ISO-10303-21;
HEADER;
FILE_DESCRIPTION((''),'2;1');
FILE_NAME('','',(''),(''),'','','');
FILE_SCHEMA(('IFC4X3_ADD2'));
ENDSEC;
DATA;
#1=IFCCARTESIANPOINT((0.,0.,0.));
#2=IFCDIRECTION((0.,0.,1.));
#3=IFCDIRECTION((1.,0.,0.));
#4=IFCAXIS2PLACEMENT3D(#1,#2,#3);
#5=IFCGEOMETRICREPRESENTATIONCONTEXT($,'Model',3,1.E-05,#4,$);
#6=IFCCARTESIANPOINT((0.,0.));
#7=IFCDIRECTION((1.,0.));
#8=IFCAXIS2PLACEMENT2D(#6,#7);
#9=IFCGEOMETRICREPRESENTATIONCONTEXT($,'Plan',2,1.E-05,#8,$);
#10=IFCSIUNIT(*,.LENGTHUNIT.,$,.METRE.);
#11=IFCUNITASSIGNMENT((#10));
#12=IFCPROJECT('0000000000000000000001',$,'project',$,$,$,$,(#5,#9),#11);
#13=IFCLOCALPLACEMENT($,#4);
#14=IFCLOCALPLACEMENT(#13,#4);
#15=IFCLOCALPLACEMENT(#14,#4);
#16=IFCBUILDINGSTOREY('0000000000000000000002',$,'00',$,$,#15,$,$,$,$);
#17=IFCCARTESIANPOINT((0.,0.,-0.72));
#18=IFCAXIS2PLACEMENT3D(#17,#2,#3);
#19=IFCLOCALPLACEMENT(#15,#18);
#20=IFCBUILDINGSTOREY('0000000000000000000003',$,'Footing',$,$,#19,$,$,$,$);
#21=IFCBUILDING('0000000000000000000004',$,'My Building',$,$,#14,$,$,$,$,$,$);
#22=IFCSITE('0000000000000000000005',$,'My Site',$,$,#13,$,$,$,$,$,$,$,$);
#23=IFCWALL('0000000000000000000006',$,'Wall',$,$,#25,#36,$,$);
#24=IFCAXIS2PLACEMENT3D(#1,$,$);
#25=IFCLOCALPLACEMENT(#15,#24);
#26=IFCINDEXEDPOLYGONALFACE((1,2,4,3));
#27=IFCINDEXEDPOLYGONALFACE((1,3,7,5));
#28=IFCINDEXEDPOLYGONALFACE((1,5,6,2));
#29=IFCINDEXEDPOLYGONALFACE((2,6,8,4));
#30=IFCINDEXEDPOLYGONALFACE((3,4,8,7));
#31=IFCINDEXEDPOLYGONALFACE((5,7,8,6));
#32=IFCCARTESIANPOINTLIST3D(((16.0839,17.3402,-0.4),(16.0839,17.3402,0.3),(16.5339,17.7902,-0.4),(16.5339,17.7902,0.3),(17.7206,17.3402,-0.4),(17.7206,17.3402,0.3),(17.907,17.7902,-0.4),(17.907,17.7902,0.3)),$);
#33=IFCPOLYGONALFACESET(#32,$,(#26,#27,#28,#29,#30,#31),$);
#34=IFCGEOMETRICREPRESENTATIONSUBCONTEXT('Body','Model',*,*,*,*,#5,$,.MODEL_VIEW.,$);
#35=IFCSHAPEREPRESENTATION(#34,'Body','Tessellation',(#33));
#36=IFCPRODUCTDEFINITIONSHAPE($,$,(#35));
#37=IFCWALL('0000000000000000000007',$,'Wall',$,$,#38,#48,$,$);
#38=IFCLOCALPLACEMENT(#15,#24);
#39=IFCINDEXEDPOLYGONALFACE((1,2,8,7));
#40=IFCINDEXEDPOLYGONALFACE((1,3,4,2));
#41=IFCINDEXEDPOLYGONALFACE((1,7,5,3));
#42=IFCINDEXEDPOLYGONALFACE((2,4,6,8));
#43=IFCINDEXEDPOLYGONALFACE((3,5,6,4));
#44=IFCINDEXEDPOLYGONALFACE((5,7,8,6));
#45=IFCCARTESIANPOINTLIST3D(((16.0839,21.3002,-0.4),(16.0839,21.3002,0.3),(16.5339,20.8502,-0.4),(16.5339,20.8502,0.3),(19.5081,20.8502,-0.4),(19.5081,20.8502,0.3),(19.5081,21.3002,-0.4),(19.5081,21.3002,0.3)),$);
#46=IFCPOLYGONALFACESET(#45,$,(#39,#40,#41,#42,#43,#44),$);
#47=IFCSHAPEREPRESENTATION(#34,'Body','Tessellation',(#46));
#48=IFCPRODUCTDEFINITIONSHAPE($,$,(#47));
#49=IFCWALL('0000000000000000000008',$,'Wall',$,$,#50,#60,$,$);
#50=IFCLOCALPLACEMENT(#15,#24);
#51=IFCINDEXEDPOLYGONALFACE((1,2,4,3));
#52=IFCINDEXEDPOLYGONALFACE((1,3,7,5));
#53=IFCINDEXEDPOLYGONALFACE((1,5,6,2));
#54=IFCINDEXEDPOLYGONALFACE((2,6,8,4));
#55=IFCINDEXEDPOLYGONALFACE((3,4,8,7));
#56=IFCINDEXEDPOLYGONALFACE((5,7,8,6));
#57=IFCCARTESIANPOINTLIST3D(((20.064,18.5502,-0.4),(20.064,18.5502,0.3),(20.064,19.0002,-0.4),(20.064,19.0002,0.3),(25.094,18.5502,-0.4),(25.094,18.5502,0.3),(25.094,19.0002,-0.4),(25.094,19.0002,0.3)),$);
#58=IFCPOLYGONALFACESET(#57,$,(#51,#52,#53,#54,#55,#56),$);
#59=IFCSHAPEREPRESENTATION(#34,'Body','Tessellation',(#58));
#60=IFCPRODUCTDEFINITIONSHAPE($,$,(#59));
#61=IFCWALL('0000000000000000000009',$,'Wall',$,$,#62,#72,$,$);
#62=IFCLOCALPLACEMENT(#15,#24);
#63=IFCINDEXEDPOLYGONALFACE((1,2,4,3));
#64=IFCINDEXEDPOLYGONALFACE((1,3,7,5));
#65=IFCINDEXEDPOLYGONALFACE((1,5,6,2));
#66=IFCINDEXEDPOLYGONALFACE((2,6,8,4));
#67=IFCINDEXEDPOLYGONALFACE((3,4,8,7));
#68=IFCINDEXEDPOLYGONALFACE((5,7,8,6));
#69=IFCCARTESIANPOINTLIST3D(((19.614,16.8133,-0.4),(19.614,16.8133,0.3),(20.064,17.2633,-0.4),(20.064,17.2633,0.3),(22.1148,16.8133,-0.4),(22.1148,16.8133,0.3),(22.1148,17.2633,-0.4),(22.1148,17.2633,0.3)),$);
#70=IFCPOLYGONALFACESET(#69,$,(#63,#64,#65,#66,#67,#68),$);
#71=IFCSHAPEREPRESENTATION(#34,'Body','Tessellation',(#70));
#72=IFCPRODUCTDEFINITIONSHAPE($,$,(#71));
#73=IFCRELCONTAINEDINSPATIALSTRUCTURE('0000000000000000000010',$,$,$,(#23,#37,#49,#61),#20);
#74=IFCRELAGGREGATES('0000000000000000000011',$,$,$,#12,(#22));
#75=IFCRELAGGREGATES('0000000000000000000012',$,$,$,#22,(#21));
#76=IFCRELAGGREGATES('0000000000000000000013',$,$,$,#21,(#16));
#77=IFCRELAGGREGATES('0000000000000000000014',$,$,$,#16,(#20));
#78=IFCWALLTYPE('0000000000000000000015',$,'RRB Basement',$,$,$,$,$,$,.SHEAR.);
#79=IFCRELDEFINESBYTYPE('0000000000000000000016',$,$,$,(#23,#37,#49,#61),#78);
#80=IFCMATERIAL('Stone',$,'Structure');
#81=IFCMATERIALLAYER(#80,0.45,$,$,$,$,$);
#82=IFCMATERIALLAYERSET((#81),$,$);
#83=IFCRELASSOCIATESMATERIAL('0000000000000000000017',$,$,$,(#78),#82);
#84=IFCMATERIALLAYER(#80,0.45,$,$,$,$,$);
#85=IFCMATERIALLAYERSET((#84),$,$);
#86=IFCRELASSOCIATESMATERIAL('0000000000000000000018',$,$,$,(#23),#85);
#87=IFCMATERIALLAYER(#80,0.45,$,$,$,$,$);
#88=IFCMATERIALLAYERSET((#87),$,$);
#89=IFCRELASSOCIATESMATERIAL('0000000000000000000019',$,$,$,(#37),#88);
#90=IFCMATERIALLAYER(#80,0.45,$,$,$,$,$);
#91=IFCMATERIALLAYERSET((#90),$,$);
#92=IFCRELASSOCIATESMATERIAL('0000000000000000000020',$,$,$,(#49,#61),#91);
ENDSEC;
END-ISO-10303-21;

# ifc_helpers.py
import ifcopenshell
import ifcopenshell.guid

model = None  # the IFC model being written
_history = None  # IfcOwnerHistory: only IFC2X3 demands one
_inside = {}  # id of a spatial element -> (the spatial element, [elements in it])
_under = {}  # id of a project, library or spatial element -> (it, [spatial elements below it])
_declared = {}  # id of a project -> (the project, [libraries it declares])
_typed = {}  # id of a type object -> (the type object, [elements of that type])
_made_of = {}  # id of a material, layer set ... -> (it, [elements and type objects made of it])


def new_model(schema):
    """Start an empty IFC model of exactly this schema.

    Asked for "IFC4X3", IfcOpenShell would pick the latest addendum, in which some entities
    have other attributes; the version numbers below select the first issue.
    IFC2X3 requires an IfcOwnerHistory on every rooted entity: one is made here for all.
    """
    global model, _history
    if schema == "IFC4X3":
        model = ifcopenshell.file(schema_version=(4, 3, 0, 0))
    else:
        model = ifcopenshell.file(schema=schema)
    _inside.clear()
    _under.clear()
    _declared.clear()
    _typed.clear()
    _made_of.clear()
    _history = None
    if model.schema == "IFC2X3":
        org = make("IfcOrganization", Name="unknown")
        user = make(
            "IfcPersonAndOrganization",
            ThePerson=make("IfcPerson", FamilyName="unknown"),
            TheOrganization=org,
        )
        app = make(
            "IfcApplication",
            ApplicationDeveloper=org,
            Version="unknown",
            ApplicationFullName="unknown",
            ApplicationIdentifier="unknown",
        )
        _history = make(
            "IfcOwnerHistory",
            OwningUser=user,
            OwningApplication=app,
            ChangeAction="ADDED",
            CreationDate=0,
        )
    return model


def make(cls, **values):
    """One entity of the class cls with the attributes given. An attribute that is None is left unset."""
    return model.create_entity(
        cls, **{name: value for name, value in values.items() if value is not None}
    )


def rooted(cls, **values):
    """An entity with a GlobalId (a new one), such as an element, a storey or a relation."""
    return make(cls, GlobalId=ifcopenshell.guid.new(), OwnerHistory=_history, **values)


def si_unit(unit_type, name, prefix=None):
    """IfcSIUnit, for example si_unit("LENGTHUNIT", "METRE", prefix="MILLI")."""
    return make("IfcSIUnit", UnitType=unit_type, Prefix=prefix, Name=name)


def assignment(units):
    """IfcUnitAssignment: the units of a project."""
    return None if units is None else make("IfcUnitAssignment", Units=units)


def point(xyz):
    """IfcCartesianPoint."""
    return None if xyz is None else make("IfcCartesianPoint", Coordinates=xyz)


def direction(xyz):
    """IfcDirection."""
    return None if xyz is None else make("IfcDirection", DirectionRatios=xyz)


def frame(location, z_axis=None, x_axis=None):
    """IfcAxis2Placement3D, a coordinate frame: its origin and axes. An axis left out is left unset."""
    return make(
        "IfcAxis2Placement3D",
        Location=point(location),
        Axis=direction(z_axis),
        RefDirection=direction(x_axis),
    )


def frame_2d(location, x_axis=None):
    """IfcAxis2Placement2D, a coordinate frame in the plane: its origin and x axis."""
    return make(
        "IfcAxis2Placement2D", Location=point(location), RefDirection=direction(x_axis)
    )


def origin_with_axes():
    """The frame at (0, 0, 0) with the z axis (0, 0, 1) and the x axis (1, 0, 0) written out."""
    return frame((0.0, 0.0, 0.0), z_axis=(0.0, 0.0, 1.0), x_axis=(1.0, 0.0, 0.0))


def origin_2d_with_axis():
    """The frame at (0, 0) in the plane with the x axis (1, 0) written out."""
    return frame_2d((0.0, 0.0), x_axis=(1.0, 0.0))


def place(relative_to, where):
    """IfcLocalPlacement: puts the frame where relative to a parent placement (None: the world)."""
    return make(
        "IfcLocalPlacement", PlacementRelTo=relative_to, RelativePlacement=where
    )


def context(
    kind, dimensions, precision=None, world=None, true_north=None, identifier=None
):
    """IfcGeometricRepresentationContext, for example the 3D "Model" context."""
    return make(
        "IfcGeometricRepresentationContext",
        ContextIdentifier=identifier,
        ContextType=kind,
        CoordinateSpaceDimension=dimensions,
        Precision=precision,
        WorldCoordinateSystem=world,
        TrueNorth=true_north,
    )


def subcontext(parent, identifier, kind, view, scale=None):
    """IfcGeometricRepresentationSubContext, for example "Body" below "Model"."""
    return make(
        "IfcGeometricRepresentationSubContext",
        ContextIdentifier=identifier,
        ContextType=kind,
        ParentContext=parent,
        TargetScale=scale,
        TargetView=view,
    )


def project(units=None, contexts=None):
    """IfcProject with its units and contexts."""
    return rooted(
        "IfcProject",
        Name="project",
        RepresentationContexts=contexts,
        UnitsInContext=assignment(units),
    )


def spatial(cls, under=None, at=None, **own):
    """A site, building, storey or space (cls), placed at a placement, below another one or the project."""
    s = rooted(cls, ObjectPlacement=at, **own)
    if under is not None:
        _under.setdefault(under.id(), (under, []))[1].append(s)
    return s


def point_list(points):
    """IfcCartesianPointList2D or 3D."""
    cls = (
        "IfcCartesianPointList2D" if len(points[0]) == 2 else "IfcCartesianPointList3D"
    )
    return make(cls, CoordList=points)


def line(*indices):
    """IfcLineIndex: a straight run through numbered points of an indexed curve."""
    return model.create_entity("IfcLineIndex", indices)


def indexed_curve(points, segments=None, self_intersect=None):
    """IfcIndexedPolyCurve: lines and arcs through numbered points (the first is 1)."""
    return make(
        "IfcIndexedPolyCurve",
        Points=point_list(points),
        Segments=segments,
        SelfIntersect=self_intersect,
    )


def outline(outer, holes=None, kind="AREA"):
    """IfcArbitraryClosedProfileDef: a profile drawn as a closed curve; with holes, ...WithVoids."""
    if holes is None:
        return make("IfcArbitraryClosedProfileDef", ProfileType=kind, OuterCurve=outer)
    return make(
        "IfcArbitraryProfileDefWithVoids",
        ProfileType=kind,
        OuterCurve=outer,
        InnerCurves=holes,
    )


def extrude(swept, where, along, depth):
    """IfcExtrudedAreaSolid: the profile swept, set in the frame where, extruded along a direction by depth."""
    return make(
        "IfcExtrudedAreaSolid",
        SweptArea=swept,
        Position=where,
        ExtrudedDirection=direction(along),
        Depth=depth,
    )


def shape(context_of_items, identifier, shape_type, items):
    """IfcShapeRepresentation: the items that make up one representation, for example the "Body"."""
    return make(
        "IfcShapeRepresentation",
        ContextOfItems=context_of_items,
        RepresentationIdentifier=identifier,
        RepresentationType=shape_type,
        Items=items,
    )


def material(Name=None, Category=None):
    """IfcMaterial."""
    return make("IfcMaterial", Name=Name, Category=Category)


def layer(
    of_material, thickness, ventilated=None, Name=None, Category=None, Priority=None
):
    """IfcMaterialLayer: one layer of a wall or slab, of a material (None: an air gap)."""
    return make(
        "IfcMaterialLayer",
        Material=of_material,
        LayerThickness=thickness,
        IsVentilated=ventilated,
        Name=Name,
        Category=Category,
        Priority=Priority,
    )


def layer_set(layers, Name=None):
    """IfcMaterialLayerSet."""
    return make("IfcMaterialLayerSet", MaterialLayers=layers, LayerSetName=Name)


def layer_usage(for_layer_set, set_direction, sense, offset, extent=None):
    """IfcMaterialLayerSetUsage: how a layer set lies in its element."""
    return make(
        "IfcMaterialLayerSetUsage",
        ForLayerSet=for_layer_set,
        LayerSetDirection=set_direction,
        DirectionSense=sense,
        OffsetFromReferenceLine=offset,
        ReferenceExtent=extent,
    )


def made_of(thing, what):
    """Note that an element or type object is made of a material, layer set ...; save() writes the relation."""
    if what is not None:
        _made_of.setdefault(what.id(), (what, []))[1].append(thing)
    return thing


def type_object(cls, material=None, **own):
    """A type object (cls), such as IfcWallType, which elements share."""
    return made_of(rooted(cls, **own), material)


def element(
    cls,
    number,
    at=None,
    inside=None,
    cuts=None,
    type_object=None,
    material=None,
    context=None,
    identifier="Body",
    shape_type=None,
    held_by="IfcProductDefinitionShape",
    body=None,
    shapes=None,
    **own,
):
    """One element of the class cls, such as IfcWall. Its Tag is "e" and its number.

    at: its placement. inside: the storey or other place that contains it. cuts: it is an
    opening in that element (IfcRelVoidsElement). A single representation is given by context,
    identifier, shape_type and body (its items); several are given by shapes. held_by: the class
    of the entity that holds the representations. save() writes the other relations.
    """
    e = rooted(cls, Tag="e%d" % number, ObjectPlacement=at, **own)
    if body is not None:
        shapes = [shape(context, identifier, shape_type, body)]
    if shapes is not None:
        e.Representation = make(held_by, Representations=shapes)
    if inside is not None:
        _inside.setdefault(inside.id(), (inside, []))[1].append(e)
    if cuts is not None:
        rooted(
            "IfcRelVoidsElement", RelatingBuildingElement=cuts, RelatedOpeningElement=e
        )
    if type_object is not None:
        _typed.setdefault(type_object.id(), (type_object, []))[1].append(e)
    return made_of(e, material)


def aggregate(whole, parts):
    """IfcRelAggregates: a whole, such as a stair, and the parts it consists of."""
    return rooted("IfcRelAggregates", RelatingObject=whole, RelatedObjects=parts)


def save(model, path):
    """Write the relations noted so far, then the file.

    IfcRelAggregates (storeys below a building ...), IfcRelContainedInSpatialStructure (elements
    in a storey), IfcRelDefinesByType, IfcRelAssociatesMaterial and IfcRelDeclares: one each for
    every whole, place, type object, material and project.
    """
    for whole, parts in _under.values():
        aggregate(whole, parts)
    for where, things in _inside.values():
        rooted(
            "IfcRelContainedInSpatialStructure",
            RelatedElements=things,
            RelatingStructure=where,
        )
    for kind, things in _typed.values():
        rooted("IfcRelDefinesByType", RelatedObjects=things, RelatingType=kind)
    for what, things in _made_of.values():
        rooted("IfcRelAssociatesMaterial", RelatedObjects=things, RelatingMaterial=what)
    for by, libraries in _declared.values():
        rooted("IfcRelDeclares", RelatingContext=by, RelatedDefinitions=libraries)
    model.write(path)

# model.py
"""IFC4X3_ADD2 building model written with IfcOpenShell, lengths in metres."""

from ifc_helpers import new_model, si_unit, frame, origin_with_axes, origin_2d_with_axis, place, context, subcontext, project, spatial, line, indexed_curve, outline, extrude, material, layer, layer_set, layer_usage, type_object, element, save


model = new_model("IFC4X3_ADD2")

# Units and contexts
model_context = context("Model", 3, precision=1e-05, world=origin_with_axes())
plan_context = context("Plan", 2, precision=1e-05, world=origin_2d_with_axis())
body_context = subcontext(model_context, "Body", "Model", "MODEL_VIEW")
ifc_project = project(units=[si_unit("LENGTHUNIT", "METRE")], contexts=[model_context, plan_context])

# Site, building, storeys
site_placement = place(None, origin_with_axes())
site = spatial("IfcSite", under=ifc_project, at=site_placement, Name="My Site")
building_placement = place(site_placement, origin_with_axes())
building = spatial("IfcBuilding", under=site, at=building_placement, Name="My Building")
storey_1_placement = place(building_placement, origin_with_axes())
storey_1 = spatial("IfcBuildingStorey", under=building, at=storey_1_placement, Name="00")
storey_2_placement = place(storey_1_placement, frame((0.0, 0.0, -0.72), z_axis=(0.0, 0.0, 1.0), x_axis=(1.0, 0.0, 0.0)))
storey_2 = spatial("IfcBuildingStorey", under=storey_1, at=storey_2_placement, Name="Footing")

# Walls
ifc_material_1 = material(Name="Stone", Category="Structure")
ifc_layer_1 = layer(ifc_material_1, 0.45)
ifc_layer_set_1 = layer_set([ifc_layer_1])
wall_type_1 = type_object("IfcWallType", Name="RRB Basement", PredefinedType="SHEAR", material=ifc_layer_set_1)
ifc_layer_2 = layer(ifc_material_1, 0.45)
ifc_layer_set_2 = layer_set([ifc_layer_2])
ifc_layer_usage_1 = layer_usage(ifc_layer_set_2, "AXIS2", "POSITIVE", 0.0)
wall_1_placement = place(storey_2_placement, frame((16.5339, 17.3402, 0.32), z_axis=(0.0, 0.0, 1.0), x_axis=(1.0, 0.0, 0.0)))
element("IfcWall", 1, at=wall_1_placement, inside=storey_2, type_object=wall_type_1, material=ifc_layer_usage_1, Name="Wall", context=body_context, shape_type="SweptSolid", body=[
    extrude(outline(indexed_curve([(-0.45, 0.0), (0.0, 0.45), (1.373, 0.45), (1.1866, 0.0)], segments=[line(1, 2, 3, 4, 1)])), origin_with_axes(), (0.0, 0.0, 1.0), 0.7),
])
ifc_layer_3 = layer(ifc_material_1, 0.45)
ifc_layer_set_3 = layer_set([ifc_layer_3])
ifc_layer_usage_2 = layer_usage(ifc_layer_set_3, "AXIS2", "POSITIVE", 0.0)
wall_2_placement = place(storey_2_placement, frame((16.5339, 20.8502, 0.32), z_axis=(0.0, 0.0, 1.0), x_axis=(1.0, 0.0, 0.0)))
element("IfcWall", 2, at=wall_2_placement, inside=storey_2, type_object=wall_type_1, material=ifc_layer_usage_2, Name="Wall", context=body_context, shape_type="SweptSolid", body=[
    extrude(outline(indexed_curve([(0.0, 0.0), (-0.45, 0.45), (2.9742, 0.45), (2.9742, 0.0)], segments=[line(1, 2, 3, 4, 1)])), origin_with_axes(), (0.0, 0.0, 1.0), 0.7),
])
ifc_layer_4 = layer(ifc_material_1, 0.45)
ifc_layer_set_4 = layer_set([ifc_layer_4])
ifc_layer_usage_3 = layer_usage(ifc_layer_set_4, "AXIS2", "POSITIVE", 0.0)
wall_3_placement = place(storey_2_placement, frame((20.064, 18.5502, 0.32), z_axis=(0.0, 0.0, 1.0), x_axis=(1.0, 0.0, 0.0)))
element("IfcWall", 3, at=wall_3_placement, inside=storey_2, type_object=wall_type_1, material=ifc_layer_usage_3, Name="Wall", context=body_context, shape_type="SweptSolid", body=[
    extrude(outline(indexed_curve([(0.0, 0.0), (0.0, 0.45), (5.03, 0.45), (5.03, 0.0)], segments=[line(1, 2, 3, 4, 1)])), origin_with_axes(), (0.0, 0.0, 1.0), 0.7),
])
ifc_layer_usage_4 = layer_usage(ifc_layer_set_4, "AXIS2", "POSITIVE", 0.0)
wall_4_placement = place(storey_2_placement, frame((20.064, 16.8133, 0.32), z_axis=(0.0, 0.0, 1.0), x_axis=(1.0, 0.0, 0.0)))
element("IfcWall", 4, at=wall_4_placement, inside=storey_2, type_object=wall_type_1, material=ifc_layer_usage_4, Name="Wall", context=body_context, shape_type="SweptSolid", body=[
    extrude(outline(indexed_curve([(-0.45, 0.0), (0.0, 0.45), (2.0508, 0.45), (2.0508, 0.0)], segments=[line(1, 2, 3, 4, 1)])), origin_with_axes(), (0.0, 0.0, 1.0), 0.7),
])

save(model, "model.ifc")
